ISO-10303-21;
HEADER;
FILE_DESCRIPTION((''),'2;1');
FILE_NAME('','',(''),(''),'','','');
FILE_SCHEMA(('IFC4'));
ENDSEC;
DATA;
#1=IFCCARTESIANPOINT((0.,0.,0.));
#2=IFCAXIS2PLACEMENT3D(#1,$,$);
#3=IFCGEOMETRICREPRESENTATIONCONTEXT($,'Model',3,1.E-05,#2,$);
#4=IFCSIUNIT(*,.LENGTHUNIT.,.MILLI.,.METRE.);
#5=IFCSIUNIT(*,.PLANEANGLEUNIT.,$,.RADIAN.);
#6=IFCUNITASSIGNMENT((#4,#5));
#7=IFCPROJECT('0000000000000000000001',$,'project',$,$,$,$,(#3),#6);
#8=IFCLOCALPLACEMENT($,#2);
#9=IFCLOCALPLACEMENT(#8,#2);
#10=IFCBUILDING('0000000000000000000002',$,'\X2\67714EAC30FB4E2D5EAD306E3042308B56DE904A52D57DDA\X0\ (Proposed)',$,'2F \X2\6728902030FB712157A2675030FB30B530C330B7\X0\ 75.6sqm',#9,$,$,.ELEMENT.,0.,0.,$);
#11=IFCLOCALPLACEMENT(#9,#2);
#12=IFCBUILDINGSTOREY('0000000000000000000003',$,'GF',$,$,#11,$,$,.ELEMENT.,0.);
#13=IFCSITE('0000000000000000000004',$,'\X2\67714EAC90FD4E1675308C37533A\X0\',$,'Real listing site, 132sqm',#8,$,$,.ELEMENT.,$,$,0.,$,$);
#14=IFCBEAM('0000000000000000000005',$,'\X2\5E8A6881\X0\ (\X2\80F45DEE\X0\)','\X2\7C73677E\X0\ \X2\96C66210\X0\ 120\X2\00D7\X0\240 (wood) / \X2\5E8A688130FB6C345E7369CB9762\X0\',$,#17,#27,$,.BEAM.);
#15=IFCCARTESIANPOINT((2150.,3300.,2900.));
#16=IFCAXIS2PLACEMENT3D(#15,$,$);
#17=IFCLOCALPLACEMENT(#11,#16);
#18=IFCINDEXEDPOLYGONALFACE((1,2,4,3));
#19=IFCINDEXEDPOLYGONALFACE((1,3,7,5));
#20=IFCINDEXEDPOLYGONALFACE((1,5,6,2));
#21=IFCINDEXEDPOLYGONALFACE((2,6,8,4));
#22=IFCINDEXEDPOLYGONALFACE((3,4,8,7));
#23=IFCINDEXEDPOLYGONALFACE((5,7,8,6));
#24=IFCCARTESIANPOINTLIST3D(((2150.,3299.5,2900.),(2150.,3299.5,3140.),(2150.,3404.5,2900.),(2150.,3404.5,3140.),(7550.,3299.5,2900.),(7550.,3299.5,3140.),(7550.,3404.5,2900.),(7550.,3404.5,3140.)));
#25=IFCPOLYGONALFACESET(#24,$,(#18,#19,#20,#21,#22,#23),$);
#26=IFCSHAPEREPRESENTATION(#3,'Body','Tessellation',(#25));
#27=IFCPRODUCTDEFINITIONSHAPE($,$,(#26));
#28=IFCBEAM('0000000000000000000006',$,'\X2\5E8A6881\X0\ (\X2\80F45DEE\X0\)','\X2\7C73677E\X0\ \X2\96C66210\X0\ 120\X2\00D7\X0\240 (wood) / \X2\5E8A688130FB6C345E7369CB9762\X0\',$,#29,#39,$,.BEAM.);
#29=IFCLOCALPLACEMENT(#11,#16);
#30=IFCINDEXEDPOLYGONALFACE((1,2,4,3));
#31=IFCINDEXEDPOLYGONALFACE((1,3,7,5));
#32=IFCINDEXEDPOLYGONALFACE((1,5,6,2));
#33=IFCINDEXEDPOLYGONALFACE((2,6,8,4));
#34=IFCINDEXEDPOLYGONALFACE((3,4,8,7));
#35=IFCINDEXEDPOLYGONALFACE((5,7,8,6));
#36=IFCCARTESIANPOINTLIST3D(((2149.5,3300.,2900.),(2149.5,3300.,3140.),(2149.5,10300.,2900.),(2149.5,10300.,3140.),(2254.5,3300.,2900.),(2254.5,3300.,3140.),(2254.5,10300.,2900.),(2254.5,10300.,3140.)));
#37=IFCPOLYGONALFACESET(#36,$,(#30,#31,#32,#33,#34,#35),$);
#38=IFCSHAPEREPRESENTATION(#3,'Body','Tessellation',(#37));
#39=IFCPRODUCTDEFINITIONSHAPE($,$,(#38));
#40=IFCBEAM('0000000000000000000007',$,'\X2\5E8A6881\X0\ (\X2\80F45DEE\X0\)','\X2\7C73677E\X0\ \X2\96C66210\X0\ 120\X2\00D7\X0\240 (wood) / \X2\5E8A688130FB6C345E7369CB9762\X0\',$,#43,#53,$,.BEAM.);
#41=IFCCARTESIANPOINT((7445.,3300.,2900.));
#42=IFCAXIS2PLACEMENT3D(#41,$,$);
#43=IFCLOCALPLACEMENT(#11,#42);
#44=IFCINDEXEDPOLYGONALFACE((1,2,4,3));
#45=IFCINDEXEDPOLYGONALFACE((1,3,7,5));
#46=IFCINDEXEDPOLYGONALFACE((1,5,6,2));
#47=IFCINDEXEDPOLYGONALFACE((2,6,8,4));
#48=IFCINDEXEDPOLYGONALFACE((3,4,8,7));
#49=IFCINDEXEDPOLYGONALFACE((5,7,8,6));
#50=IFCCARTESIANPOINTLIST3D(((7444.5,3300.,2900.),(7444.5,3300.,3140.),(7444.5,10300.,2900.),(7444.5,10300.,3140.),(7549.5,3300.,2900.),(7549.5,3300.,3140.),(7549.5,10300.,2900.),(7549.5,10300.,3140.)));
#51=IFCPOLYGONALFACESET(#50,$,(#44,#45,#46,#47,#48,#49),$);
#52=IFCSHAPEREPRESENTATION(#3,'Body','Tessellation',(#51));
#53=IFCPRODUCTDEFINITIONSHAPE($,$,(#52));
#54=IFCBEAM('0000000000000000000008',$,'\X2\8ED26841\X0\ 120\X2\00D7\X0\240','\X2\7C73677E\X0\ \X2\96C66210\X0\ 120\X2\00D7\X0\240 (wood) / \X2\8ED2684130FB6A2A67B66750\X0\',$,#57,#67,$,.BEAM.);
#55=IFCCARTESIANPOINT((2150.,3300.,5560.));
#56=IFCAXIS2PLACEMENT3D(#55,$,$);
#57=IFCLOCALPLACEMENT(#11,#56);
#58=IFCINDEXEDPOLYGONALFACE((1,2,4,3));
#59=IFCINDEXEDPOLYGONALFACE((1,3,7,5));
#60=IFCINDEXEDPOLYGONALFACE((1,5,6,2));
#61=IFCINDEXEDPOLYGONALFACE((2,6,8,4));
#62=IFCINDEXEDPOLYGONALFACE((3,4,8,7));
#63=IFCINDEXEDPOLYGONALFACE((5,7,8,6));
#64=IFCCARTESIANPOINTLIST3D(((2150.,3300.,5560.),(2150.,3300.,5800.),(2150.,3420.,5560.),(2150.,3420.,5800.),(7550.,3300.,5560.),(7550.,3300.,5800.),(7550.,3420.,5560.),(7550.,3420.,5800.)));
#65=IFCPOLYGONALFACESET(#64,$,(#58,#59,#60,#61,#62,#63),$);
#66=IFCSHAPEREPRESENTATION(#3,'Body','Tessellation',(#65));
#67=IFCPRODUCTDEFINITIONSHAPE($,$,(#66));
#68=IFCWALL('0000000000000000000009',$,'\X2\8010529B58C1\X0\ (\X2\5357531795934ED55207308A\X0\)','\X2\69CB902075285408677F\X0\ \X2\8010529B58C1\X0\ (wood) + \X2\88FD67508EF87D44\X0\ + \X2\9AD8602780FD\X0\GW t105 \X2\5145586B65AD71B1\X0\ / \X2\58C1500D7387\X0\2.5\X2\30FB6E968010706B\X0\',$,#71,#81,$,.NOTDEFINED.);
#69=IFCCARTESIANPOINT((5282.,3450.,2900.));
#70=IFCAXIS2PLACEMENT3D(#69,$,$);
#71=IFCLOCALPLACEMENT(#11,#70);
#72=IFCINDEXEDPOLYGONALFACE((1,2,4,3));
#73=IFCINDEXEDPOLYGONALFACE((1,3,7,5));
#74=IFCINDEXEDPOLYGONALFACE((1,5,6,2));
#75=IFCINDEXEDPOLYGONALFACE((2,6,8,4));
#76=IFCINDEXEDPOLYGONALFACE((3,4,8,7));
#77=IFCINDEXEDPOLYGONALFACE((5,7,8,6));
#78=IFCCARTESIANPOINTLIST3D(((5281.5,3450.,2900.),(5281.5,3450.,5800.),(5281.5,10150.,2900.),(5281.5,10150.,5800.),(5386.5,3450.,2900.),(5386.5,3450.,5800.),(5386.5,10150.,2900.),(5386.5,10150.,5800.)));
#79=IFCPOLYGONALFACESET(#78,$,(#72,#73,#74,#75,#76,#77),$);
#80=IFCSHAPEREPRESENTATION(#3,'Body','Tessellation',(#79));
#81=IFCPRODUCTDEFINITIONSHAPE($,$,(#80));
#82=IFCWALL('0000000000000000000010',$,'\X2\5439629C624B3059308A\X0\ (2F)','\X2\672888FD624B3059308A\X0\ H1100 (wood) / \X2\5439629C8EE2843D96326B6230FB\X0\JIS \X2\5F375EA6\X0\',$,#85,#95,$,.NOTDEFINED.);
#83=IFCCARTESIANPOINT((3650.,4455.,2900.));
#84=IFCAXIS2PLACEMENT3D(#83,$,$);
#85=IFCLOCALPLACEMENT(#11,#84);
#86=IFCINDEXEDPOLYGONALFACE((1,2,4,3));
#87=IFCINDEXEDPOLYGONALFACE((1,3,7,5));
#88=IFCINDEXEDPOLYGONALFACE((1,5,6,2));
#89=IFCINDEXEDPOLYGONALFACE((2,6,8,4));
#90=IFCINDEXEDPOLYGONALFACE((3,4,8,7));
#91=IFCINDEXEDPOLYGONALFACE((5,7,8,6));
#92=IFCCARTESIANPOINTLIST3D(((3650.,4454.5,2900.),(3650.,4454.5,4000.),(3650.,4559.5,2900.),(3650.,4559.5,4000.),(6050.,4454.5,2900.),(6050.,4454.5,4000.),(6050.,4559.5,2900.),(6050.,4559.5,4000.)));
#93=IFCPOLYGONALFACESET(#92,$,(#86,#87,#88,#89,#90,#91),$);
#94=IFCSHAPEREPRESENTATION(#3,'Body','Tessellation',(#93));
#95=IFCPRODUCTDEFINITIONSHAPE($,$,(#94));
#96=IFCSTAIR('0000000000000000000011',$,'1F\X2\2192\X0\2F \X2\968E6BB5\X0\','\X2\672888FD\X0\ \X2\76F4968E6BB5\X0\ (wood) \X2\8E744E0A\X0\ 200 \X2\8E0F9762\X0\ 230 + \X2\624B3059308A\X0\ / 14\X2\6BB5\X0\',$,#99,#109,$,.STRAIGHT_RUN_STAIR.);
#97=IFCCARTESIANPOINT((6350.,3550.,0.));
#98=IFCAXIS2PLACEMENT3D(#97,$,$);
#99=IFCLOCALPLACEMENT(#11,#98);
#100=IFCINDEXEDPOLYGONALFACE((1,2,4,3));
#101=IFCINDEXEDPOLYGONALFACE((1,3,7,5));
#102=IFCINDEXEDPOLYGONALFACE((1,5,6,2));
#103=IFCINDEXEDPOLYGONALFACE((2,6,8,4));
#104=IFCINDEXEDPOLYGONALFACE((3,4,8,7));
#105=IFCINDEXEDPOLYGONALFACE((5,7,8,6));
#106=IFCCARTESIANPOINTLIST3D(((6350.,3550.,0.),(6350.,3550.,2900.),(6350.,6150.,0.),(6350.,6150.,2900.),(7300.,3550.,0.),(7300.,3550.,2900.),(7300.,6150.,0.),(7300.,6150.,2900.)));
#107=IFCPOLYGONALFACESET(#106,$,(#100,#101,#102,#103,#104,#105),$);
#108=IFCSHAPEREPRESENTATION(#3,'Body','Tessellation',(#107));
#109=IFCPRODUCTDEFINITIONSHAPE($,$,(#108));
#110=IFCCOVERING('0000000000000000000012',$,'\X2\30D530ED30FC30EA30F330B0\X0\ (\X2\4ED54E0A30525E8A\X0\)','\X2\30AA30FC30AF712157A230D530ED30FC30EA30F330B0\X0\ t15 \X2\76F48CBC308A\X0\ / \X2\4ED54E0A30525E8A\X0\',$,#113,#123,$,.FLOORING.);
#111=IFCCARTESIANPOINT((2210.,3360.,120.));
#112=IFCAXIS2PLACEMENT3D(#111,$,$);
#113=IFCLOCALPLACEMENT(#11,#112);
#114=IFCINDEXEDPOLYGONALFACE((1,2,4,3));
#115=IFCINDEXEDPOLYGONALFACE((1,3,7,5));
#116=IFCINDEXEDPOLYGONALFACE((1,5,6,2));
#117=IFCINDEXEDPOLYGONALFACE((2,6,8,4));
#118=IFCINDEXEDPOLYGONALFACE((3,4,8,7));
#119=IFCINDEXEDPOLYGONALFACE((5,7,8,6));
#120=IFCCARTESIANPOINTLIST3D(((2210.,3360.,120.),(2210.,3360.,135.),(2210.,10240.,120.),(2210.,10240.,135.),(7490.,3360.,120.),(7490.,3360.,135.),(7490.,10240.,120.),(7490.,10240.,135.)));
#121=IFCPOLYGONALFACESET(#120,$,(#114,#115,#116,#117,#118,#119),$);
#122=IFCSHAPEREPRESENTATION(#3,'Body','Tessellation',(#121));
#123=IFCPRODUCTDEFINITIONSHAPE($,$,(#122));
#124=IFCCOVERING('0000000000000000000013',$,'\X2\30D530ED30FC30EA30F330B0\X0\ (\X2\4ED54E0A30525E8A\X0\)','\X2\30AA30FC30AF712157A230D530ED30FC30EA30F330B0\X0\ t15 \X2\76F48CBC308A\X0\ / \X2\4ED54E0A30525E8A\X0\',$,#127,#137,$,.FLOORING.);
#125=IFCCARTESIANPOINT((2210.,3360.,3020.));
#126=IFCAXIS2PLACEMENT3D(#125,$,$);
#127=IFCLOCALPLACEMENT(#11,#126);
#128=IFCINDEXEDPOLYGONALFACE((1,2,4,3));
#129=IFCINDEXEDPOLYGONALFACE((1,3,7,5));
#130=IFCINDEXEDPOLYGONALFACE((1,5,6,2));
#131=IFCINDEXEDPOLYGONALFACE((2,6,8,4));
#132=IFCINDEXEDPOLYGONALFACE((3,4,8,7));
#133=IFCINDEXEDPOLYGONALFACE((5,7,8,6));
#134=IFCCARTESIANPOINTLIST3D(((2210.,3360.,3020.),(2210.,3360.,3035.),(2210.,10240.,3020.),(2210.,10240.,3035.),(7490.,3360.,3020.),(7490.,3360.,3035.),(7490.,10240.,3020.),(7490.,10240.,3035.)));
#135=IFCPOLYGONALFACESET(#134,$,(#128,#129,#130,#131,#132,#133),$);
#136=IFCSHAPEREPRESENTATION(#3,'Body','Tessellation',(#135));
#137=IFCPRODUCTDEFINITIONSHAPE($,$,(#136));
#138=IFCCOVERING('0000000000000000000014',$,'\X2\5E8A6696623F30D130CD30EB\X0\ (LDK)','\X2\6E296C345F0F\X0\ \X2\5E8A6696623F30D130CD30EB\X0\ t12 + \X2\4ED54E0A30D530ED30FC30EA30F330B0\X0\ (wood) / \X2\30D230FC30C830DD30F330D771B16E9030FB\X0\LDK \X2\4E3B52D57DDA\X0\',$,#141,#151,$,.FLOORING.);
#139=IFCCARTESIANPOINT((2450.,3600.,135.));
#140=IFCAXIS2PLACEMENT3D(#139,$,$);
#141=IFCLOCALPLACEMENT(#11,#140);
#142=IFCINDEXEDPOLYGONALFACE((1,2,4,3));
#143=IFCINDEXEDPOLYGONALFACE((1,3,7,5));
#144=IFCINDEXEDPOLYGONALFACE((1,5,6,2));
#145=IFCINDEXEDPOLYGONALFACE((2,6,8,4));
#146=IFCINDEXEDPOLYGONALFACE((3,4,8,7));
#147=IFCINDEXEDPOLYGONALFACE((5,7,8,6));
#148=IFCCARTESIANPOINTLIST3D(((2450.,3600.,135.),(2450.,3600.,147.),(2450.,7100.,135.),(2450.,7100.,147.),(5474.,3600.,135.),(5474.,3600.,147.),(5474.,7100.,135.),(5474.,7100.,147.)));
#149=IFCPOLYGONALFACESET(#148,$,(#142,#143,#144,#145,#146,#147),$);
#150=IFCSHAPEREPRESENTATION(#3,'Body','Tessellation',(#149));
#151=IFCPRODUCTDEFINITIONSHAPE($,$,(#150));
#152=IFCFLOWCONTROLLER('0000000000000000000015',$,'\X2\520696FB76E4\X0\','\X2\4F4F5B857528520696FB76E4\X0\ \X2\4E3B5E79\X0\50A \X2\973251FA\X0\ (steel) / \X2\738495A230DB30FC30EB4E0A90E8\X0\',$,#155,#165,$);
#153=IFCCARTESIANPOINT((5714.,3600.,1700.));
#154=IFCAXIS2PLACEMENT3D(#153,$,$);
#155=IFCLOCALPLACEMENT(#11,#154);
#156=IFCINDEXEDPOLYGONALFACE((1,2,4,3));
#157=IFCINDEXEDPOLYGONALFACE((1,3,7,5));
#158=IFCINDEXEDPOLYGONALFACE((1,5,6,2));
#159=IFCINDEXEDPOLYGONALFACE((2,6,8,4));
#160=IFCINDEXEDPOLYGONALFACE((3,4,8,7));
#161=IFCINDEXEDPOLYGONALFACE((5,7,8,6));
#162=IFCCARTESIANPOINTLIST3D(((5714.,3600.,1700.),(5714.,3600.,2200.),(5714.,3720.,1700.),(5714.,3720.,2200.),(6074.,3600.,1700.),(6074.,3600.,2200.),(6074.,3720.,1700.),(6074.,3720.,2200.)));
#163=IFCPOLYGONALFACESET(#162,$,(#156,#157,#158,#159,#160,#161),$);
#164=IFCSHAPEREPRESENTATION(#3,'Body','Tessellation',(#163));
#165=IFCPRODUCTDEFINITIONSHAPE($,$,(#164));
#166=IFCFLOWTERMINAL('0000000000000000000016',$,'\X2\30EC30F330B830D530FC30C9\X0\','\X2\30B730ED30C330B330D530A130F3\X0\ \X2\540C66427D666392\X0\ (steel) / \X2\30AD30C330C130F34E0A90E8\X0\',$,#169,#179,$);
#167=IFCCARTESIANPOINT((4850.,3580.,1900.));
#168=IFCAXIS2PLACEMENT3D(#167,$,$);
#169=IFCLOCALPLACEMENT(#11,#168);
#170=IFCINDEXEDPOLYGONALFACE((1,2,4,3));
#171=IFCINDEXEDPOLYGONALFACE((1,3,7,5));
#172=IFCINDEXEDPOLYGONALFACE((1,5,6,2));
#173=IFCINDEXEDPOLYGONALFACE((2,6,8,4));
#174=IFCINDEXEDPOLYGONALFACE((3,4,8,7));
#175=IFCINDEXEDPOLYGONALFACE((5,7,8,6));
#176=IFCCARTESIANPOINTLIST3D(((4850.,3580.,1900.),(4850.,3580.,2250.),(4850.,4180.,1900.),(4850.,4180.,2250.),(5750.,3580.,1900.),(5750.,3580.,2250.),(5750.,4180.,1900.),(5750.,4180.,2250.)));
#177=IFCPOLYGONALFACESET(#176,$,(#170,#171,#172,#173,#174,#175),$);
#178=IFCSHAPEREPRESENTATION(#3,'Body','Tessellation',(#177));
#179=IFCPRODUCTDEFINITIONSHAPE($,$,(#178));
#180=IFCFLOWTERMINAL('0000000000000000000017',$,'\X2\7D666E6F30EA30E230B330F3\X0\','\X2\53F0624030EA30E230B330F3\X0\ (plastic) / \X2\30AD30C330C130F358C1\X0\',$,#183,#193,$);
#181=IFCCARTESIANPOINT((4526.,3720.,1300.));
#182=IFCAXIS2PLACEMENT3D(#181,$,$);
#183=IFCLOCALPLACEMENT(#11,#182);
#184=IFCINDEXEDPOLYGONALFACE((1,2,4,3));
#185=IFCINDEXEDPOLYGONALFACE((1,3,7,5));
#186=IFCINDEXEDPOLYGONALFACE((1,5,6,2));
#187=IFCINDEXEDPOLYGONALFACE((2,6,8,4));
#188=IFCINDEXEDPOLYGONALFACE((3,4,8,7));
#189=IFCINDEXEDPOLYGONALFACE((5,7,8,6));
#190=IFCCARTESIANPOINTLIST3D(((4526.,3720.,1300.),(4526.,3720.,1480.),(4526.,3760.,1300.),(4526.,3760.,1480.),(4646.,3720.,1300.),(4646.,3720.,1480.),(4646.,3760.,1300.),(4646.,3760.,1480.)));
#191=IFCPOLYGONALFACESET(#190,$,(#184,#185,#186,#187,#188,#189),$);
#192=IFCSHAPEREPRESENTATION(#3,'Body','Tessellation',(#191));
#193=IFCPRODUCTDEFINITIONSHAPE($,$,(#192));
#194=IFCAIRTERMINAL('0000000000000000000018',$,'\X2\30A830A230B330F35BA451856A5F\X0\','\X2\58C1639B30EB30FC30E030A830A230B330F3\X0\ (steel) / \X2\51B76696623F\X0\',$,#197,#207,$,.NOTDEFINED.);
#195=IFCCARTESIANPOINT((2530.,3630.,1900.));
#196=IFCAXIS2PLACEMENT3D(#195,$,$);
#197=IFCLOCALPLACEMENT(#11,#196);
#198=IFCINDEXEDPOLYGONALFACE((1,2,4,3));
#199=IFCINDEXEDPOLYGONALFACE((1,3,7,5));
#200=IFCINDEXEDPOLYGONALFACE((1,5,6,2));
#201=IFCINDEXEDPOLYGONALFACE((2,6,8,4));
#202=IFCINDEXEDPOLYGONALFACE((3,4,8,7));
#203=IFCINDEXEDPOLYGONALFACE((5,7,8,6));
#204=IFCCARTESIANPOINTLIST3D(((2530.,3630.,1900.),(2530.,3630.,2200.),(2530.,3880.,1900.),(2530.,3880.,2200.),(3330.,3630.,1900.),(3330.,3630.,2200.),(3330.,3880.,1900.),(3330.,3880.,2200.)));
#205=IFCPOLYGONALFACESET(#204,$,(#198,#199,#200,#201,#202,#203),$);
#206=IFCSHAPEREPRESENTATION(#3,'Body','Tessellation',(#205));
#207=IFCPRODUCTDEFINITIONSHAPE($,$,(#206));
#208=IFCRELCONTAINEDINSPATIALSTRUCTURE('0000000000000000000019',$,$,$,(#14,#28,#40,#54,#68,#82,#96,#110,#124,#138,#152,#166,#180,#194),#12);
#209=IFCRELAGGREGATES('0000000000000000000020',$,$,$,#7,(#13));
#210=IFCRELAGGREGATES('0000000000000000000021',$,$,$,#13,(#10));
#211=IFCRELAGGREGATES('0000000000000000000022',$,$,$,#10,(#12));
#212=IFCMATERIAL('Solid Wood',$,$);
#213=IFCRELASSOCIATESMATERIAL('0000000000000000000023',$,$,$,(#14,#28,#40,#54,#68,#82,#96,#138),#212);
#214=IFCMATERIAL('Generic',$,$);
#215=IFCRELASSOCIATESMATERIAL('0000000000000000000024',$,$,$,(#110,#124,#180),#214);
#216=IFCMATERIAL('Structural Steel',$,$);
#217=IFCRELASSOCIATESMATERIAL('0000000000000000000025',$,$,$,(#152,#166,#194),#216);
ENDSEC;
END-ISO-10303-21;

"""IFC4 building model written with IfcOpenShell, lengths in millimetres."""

from ifc_helpers import new_model, si_unit, frame, frame_2d, origin, place, context, project, spatial, rectangle, extrude, material, element, save


model = new_model("IFC4")

# Units and contexts
model_context = context("Model", 3, precision=1e-05, world=origin())
ifc_project = project(units=[si_unit("LENGTHUNIT", "METRE", prefix="MILLI"), si_unit("PLANEANGLEUNIT", "RADIAN")], contexts=[model_context])

# Site, building, storey
site_placement = place(None, origin())
site = spatial("IfcSite", under=ifc_project, at=site_placement, Name="東京都世田谷区", ObjectType="Real listing site, 132sqm", CompositionType="ELEMENT", RefElevation=0.0)
building_placement = place(site_placement, origin())
building = spatial("IfcBuilding", under=site, at=building_placement, Name="東京・中庭のある回遊動線 (Proposed)", ObjectType="2F 木造・無垢材・サッシ 75.6sqm", CompositionType="ELEMENT", ElevationOfRefHeight=0.0, ElevationOfTerrain=0.0)
storey_placement = place(building_placement, origin())
storey = spatial("IfcBuildingStorey", under=building, at=storey_placement, Name="GF", CompositionType="ELEMENT", Elevation=0.0)

# Shared definitions
ifc_material_1 = material(Name="Solid Wood")

# Beams
beam_1_placement = place(storey_placement, frame((2150.0, 3300.0, 2900.0)))
element("IfcBeam", 1, at=beam_1_placement, inside=storey, material=ifc_material_1, Name="床梁 (胴差)", Description="米松 集成 120×240 (wood) / 床梁・水平構面", PredefinedType="BEAM", context=model_context, shape_type="SweptSolid", body=[
    extrude(rectangle(XDim=5400.0, YDim=105.0, at=frame_2d((2700.0, 52.0))), frame((2150.0, 3300.0, 2900.0)), (0.0, 0.0, 1.0), 240.0),
])
beam_2_placement = place(storey_placement, frame((2150.0, 3300.0, 2900.0)))
element("IfcBeam", 2, at=beam_2_placement, inside=storey, material=ifc_material_1, Name="床梁 (胴差)", Description="米松 集成 120×240 (wood) / 床梁・水平構面", PredefinedType="BEAM", context=model_context, shape_type="SweptSolid", body=[
    extrude(rectangle(XDim=105.0, YDim=7000.0, at=frame_2d((52.0, 3500.0))), frame((2150.0, 3300.0, 2900.0)), (0.0, 0.0, 1.0), 240.0),
])
beam_3_placement = place(storey_placement, frame((7445.0, 3300.0, 2900.0)))
element("IfcBeam", 3, at=beam_3_placement, inside=storey, material=ifc_material_1, Name="床梁 (胴差)", Description="米松 集成 120×240 (wood) / 床梁・水平構面", PredefinedType="BEAM", context=model_context, shape_type="SweptSolid", body=[
    extrude(rectangle(XDim=105.0, YDim=7000.0, at=frame_2d((52.0, 3500.0))), frame((7445.0, 3300.0, 2900.0)), (0.0, 0.0, 1.0), 240.0),
])
beam_4_placement = place(storey_placement, frame((2150.0, 3300.0, 5560.0)))
element("IfcBeam", 4, at=beam_4_placement, inside=storey, material=ifc_material_1, Name="軒桁 120×240", Description="米松 集成 120×240 (wood) / 軒桁・横架材", PredefinedType="BEAM", context=model_context, shape_type="SweptSolid", body=[
    extrude(rectangle(XDim=5400.0, YDim=120.0, at=frame_2d((2700.0, 60.0))), frame((2150.0, 3300.0, 5560.0)), (0.0, 0.0, 1.0), 240.0),
])

# Walls
wall_1_placement = place(storey_placement, frame((5282.0, 3450.0, 2900.0)))
element("IfcWall", 5, at=wall_1_placement, inside=storey, material=ifc_material_1, Name="耐力壁 (南北間仕切り)", Description="構造用合板 耐力壁 (wood) + 製材軸組 + 高性能GW t105 充填断熱 / 壁倍率2.5・準耐火", PredefinedType="NOTDEFINED", context=model_context, shape_type="SweptSolid", body=[
    extrude(rectangle(XDim=105.0, YDim=6700.0, at=frame_2d((52.0, 3350.0))), frame((5282.0, 3450.0, 2900.0)), (0.0, 0.0, 1.0), 2900.0),
])
wall_2_placement = place(storey_placement, frame((3650.0, 4455.0, 2900.0)))
element("IfcWall", 6, at=wall_2_placement, inside=storey, material=ifc_material_1, Name="吹抜手すり (2F)", Description="木製手すり H1100 (wood) / 吹抜転落防止・JIS 強度", PredefinedType="NOTDEFINED", context=model_context, shape_type="SweptSolid", body=[
    extrude(rectangle(XDim=2400.0, YDim=105.0, at=frame_2d((1200.0, 52.0))), frame((3650.0, 4455.0, 2900.0)), (0.0, 0.0, 1.0), 1100.0),
])

# Stair
stair_placement = place(storey_placement, frame((6350.0, 3550.0, 0.0)))
element("IfcStair", 7, at=stair_placement, inside=storey, material=ifc_material_1, Name="1F→2F 階段", Description="木製 直階段 (wood) 蹴上 200 踏面 230 + 手すり / 14段", PredefinedType="STRAIGHT_RUN_STAIR", context=model_context, shape_type="SweptSolid", body=[
    extrude(rectangle(XDim=950.0, YDim=2600.0, at=frame_2d((475.0, 1300.0))), frame((6350.0, 3550.0, 0.0)), (0.0, 0.0, 1.0), 2900.0),
])

# Coverings
ifc_material_2 = material(Name="Generic")
covering_1_placement = place(storey_placement, frame((2210.0, 3360.0, 120.0)))
element("IfcCovering", 8, at=covering_1_placement, inside=storey, material=ifc_material_2, Name="フローリング (仕上げ床)", Description="オーク無垢フローリング t15 直貼り / 仕上げ床", PredefinedType="FLOORING", context=model_context, shape_type="SweptSolid", body=[
    extrude(rectangle(XDim=5280.0, YDim=6880.0, at=frame_2d((2640.0, 3440.0))), frame((2210.0, 3360.0, 120.0)), (0.0, 0.0, 1.0), 15.0),
])
covering_2_placement = place(storey_placement, frame((2210.0, 3360.0, 3020.0)))
element("IfcCovering", 9, at=covering_2_placement, inside=storey, material=ifc_material_2, Name="フローリング (仕上げ床)", Description="オーク無垢フローリング t15 直貼り / 仕上げ床", PredefinedType="FLOORING", context=model_context, shape_type="SweptSolid", body=[
    extrude(rectangle(XDim=5280.0, YDim=6880.0, at=frame_2d((2640.0, 3440.0))), frame((2210.0, 3360.0, 3020.0)), (0.0, 0.0, 1.0), 15.0),
])
covering_3_placement = place(storey_placement, frame((2450.0, 3600.0, 135.0)))
element("IfcCovering", 10, at=covering_3_placement, inside=storey, material=ifc_material_1, Name="床暖房パネル (LDK)", Description="温水式 床暖房パネル t12 + 仕上フローリング (wood) / ヒートポンプ熱源・LDK 主動線", PredefinedType="FLOORING", context=model_context, shape_type="SweptSolid", body=[
    extrude(rectangle(XDim=3024.0, YDim=3500.0, at=frame_2d((1512.0, 1750.0))), frame((2450.0, 3600.0, 135.0)), (0.0, 0.0, 1.0), 12.0),
])

# Flow controller
ifc_material_3 = material(Name="Structural Steel")
flow_controller_placement = place(storey_placement, frame((5714.0, 3600.0, 1700.0)))
element("IfcFlowController", 11, at=flow_controller_placement, inside=storey, material=ifc_material_3, Name="分電盤", Description="住宅用分電盤 主幹50A 露出 (steel) / 玄関ホール上部", context=model_context, shape_type="SweptSolid", body=[
    extrude(rectangle(XDim=360.0, YDim=120.0, at=frame_2d((180.0, 60.0))), frame((5714.0, 3600.0, 1700.0)), (0.0, 0.0, 1.0), 500.0),
])

# Flow terminals
flow_terminal_1_placement = place(storey_placement, frame((4850.0, 3580.0, 1900.0)))
element("IfcFlowTerminal", 12, at=flow_terminal_1_placement, inside=storey, material=ifc_material_3, Name="レンジフード", Description="シロッコファン 同時給排 (steel) / キッチン上部", context=model_context, shape_type="SweptSolid", body=[
    extrude(rectangle(XDim=900.0, YDim=600.0, at=frame_2d((450.0, 300.0))), frame((4850.0, 3580.0, 1900.0)), (0.0, 0.0, 1.0), 350.0),
])
flow_terminal_2_placement = place(storey_placement, frame((4526.0, 3720.0, 1300.0)))
element("IfcFlowTerminal", 13, at=flow_terminal_2_placement, inside=storey, material=ifc_material_2, Name="給湯リモコン", Description="台所リモコン (plastic) / キッチン壁", context=model_context, shape_type="SweptSolid", body=[
    extrude(rectangle(XDim=120.0, YDim=40.0, at=frame_2d((60.0, 20.0))), frame((4526.0, 3720.0, 1300.0)), (0.0, 0.0, 1.0), 180.0),
])

# Air terminal
air_terminal_1_placement = place(storey_placement, frame((2530.0, 3630.0, 1900.0)))
element("IfcAirTerminal", 14, at=air_terminal_1_placement, inside=storey, material=ifc_material_3, Name="エアコン室内機", Description="壁掛ルームエアコン (steel) / 冷暖房", PredefinedType="NOTDEFINED", context=model_context, shape_type="SweptSolid", body=[
    extrude(rectangle(XDim=800.0, YDim=250.0, at=frame_2d((400.0, 125.0))), frame((2530.0, 3630.0, 1900.0)), (0.0, 0.0, 1.0), 300.0),
])

save(model, "model.ifc")
